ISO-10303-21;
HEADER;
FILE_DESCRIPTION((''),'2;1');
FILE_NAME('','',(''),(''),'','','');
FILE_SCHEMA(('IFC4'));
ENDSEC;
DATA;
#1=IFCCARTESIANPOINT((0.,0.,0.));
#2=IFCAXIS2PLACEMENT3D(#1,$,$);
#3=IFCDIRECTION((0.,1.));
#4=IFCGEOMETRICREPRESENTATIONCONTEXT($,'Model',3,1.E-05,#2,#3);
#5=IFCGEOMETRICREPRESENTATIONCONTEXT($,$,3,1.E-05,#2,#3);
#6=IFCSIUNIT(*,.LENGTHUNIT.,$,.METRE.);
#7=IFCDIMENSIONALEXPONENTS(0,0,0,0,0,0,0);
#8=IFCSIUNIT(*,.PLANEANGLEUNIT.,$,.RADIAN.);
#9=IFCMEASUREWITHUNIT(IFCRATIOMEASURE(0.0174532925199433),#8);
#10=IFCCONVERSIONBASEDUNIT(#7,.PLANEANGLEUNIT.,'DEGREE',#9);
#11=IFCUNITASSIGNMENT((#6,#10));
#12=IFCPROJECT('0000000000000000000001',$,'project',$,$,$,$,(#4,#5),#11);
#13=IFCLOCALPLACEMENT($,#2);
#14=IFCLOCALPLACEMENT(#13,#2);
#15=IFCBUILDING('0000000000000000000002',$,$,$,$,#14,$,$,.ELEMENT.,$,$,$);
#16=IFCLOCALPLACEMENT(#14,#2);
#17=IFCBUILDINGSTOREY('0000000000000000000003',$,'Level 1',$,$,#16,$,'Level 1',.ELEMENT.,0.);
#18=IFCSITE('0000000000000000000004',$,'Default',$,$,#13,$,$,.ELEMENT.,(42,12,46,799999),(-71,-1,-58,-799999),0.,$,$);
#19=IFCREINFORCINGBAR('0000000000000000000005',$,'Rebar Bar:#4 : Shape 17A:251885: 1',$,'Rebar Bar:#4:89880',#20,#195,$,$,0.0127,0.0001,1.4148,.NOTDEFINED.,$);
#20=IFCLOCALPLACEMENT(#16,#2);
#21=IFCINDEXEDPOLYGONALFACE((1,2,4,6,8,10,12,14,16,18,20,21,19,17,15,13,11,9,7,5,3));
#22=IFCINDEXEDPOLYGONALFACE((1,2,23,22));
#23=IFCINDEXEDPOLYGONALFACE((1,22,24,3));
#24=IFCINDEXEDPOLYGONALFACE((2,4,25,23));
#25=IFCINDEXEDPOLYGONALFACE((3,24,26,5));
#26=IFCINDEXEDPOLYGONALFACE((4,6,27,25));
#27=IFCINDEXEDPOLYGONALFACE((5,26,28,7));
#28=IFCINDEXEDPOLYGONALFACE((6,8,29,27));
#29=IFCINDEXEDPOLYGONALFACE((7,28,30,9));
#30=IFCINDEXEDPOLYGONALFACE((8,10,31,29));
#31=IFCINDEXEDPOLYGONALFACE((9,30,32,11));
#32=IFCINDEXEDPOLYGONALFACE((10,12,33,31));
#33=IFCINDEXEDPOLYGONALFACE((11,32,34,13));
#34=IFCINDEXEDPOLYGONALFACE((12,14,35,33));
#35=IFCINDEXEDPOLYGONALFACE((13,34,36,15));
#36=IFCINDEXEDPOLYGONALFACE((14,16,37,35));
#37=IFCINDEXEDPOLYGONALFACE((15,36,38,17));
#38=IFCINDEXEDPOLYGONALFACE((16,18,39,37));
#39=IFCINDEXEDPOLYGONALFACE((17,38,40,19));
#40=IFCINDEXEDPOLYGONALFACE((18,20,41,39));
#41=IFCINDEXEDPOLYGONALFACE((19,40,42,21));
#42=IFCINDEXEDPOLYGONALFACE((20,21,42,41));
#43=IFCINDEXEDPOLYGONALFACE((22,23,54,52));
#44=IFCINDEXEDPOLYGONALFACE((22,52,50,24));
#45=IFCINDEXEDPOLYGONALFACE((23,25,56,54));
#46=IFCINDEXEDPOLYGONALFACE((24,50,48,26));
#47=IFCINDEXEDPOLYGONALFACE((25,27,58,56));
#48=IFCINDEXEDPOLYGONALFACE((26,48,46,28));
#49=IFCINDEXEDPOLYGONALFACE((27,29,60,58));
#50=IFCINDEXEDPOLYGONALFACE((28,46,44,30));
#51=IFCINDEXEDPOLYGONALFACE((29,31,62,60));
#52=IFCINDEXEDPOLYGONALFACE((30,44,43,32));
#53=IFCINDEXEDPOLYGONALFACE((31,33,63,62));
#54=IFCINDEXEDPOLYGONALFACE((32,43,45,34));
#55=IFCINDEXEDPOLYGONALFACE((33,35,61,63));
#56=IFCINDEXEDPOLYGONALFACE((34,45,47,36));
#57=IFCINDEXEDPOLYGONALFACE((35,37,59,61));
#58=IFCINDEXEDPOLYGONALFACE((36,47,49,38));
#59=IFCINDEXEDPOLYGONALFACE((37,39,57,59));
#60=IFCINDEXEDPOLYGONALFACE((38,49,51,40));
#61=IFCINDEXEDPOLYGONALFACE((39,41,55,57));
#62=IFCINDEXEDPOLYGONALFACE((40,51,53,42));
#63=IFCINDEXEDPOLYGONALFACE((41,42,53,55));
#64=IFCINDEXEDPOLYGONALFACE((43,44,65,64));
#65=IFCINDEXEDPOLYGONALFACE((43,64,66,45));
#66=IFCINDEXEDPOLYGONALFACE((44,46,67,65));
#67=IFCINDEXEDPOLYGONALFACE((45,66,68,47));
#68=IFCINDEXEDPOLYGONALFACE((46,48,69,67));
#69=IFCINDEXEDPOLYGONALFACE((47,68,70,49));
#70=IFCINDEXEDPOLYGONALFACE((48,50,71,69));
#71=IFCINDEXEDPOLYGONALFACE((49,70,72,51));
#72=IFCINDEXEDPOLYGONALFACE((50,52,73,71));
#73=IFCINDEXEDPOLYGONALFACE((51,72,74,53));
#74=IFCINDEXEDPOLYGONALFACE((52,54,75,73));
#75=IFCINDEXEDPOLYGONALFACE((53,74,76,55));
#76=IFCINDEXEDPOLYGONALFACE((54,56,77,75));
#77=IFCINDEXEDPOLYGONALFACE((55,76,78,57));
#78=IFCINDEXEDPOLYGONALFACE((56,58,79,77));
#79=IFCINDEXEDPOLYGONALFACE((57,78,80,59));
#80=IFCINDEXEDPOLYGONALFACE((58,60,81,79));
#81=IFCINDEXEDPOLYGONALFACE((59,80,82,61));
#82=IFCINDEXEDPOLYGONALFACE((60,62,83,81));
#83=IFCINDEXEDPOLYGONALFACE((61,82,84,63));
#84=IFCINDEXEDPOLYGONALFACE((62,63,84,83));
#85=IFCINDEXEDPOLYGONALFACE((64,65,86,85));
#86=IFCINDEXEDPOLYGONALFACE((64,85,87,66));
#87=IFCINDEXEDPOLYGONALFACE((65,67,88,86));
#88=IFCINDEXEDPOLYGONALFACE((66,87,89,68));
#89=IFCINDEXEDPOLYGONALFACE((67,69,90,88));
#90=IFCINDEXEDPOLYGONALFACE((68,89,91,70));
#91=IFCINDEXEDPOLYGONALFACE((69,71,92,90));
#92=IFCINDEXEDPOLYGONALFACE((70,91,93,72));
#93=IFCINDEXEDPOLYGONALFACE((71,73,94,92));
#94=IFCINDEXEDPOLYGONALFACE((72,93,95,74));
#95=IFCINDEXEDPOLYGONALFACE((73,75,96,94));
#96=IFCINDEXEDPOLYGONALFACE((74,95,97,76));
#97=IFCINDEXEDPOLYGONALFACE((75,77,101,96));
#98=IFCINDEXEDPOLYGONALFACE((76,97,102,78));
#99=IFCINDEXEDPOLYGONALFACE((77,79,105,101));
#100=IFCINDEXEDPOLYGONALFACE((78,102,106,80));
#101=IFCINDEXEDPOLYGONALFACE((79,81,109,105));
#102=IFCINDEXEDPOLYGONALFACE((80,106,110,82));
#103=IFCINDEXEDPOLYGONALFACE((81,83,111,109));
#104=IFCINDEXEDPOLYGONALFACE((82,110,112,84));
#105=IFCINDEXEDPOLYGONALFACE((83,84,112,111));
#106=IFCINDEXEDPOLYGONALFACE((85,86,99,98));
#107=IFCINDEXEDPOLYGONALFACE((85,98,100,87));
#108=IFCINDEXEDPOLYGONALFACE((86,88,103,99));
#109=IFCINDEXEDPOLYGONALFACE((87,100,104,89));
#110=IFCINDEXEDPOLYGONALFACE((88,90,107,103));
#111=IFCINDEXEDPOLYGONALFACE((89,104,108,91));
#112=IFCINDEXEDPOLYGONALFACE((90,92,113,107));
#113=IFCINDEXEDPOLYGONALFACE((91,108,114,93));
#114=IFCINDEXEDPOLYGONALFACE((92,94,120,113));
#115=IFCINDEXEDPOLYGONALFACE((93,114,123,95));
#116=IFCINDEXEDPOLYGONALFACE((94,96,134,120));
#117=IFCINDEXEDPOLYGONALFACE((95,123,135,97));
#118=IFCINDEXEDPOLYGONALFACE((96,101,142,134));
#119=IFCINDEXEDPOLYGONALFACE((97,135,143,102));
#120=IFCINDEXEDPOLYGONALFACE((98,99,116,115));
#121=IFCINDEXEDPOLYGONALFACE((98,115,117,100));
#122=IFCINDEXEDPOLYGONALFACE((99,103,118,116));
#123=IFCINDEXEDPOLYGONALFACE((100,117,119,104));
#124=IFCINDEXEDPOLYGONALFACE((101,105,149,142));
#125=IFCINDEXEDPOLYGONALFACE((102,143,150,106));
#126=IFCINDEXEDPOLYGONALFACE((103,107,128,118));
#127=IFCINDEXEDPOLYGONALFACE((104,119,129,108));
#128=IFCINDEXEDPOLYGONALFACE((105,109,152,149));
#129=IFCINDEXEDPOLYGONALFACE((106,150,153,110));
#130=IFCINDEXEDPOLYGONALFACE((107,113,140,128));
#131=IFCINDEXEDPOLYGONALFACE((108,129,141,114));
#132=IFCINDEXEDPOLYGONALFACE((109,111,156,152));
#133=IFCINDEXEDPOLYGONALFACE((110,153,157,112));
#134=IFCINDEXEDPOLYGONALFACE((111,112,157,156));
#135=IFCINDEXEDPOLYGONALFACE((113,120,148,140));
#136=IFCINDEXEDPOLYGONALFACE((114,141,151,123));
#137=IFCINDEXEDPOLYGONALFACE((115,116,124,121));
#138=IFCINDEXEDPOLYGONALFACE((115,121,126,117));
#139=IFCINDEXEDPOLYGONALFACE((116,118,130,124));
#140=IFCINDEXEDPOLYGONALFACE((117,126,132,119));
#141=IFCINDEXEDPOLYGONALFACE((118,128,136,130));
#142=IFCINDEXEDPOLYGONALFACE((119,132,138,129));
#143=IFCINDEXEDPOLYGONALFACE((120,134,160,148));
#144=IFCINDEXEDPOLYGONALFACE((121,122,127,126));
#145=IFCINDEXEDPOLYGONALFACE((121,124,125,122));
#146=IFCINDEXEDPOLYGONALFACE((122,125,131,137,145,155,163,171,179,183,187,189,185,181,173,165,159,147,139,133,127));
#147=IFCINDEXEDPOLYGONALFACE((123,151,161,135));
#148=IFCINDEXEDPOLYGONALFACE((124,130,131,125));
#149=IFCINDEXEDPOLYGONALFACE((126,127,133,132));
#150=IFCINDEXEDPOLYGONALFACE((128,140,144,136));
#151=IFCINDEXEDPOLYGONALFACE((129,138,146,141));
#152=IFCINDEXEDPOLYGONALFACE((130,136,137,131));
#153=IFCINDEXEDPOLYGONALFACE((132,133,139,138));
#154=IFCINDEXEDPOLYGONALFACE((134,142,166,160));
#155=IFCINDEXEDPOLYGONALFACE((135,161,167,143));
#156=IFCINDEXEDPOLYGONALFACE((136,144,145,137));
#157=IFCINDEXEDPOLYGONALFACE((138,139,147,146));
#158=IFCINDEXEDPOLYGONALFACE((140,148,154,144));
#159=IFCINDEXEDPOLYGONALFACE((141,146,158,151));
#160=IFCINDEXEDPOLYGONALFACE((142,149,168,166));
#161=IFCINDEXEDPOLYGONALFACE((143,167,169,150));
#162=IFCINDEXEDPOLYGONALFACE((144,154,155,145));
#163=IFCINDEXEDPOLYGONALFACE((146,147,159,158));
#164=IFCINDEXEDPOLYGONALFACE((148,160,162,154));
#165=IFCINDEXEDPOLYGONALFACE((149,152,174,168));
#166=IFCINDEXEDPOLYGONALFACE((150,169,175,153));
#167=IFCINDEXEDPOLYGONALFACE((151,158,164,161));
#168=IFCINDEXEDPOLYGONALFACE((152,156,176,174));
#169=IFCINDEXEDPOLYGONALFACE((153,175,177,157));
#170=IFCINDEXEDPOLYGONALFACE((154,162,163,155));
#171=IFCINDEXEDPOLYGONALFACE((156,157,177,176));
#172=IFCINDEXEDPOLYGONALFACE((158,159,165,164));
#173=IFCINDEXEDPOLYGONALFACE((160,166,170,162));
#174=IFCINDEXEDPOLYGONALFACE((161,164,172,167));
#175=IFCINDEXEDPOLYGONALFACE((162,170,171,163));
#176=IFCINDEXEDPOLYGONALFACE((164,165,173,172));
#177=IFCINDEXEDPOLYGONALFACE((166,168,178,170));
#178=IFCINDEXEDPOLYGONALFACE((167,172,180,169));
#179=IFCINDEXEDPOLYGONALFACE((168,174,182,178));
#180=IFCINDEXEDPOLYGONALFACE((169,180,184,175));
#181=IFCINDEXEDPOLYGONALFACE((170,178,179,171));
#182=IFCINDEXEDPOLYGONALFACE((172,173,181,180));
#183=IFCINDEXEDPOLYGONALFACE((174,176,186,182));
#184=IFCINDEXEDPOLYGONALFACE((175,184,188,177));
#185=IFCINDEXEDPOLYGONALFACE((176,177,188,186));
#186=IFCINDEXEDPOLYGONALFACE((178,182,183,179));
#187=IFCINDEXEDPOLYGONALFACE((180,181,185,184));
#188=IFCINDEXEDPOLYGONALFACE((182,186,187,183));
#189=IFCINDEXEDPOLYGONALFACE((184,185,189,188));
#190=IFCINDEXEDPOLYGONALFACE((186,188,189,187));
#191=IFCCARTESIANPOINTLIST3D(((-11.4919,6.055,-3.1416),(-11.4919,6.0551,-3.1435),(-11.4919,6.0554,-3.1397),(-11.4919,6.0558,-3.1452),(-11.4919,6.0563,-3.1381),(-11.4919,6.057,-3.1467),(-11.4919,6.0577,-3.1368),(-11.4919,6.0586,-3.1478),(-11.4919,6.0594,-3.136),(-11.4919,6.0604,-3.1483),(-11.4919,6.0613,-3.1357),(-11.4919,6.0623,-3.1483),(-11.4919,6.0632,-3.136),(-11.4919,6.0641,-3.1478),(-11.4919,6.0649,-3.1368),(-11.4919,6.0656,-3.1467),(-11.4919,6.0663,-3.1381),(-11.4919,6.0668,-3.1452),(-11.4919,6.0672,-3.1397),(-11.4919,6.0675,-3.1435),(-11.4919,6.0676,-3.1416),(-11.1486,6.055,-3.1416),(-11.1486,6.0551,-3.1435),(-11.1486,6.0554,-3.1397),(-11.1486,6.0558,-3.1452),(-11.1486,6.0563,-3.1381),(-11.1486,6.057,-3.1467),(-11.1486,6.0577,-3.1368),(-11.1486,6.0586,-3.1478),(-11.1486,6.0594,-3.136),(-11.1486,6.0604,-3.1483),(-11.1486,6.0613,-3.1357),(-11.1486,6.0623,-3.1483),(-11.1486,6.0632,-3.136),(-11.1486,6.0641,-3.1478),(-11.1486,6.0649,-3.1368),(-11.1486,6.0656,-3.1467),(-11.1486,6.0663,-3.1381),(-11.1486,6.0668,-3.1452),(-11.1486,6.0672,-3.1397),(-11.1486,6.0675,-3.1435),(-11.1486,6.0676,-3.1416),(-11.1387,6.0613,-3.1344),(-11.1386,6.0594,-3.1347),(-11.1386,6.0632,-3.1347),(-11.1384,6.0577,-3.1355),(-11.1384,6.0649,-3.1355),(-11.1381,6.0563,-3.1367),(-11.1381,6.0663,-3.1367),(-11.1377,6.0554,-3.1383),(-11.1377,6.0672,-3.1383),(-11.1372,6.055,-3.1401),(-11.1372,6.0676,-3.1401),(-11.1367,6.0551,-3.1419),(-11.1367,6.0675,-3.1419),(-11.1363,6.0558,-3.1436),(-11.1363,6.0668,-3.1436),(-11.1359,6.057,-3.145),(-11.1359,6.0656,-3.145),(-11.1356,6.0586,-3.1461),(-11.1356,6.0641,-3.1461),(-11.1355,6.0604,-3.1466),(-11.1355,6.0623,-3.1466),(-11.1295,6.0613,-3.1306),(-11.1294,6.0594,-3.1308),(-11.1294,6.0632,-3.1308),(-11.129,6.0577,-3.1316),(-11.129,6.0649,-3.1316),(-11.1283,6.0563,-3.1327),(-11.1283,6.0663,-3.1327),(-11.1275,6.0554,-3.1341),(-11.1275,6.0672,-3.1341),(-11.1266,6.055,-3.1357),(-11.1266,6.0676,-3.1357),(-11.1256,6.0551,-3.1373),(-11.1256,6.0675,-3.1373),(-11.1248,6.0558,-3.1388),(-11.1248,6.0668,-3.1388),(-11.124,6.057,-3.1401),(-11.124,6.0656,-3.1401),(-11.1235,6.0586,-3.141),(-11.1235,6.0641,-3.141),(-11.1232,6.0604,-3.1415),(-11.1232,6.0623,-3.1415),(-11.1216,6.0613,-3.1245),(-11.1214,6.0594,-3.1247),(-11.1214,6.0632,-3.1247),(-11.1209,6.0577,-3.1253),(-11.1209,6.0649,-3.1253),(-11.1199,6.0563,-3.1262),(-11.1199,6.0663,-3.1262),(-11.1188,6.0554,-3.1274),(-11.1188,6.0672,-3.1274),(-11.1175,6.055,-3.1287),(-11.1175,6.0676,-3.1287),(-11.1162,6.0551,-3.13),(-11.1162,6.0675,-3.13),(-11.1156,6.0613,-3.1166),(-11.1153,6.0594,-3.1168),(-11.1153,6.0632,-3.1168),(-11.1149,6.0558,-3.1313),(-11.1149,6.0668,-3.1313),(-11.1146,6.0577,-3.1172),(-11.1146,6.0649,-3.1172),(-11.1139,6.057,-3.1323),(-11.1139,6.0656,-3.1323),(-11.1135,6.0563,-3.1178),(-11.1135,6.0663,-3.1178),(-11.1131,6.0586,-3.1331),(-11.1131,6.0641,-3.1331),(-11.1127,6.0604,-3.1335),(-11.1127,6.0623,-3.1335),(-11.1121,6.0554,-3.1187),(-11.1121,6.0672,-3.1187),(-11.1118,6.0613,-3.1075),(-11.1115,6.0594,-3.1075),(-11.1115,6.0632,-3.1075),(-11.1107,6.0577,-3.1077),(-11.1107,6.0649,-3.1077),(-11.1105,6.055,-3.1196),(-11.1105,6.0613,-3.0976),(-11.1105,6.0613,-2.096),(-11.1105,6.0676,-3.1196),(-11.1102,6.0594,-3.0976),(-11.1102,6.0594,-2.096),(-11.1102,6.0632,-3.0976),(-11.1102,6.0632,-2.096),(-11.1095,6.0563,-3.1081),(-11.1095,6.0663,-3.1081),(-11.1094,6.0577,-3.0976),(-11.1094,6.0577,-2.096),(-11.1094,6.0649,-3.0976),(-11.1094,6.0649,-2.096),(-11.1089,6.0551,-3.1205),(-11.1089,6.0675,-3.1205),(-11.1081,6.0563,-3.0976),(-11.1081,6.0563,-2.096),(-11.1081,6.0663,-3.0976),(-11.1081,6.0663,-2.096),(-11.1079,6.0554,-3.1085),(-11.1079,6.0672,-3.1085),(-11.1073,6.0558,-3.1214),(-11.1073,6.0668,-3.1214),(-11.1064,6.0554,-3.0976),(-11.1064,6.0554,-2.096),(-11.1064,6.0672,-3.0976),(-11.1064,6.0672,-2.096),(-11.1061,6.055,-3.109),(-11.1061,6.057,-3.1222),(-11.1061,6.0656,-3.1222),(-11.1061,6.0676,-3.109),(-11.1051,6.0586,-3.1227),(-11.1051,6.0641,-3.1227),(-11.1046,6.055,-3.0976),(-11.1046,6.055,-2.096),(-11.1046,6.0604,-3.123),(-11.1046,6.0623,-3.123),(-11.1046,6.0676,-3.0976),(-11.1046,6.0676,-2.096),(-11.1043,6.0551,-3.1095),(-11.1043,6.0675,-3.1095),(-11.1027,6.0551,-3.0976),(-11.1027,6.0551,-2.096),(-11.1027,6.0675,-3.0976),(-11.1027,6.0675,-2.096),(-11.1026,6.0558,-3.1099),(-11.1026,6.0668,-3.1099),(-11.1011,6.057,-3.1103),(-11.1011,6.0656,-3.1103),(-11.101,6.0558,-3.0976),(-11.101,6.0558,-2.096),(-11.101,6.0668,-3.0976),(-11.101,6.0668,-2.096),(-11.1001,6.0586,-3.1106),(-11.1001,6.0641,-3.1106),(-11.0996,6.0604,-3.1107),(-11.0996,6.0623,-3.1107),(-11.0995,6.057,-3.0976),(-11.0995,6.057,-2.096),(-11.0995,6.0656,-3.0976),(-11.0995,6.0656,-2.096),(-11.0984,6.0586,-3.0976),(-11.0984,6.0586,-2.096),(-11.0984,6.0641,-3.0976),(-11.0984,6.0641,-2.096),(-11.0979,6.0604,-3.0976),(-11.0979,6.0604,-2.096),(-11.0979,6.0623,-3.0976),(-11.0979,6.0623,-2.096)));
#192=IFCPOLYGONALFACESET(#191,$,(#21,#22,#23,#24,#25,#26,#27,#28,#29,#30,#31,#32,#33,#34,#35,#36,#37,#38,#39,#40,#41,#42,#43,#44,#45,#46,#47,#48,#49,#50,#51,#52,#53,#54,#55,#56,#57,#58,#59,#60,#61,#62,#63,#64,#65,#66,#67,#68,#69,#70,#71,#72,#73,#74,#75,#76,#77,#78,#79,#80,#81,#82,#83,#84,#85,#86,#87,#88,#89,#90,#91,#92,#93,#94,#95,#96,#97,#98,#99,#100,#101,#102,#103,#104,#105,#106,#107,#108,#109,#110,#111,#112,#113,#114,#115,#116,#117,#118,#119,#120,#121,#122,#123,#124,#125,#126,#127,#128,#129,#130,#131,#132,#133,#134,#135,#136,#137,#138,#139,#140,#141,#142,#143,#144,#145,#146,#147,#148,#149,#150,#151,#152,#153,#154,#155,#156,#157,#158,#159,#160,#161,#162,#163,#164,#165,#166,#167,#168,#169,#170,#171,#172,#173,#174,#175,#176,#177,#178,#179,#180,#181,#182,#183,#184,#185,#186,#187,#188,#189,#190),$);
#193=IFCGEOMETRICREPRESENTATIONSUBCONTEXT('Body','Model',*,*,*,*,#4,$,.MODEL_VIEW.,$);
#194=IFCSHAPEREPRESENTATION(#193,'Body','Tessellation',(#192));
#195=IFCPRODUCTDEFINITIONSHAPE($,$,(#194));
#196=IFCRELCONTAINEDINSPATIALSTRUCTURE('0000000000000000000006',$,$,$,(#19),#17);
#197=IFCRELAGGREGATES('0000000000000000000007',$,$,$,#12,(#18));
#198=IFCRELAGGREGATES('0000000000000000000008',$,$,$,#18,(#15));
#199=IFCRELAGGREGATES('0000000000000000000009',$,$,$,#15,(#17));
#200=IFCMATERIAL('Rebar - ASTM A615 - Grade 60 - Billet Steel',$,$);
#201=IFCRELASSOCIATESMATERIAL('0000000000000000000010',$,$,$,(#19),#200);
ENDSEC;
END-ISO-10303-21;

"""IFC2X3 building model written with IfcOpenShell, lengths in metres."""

from ifc_helpers import new_model, entity, si_unit, converted_unit, direction, origin, place, context, subcontext, project, spatial, material, element, save


model = new_model("IFC2X3")

# Units and contexts
model_context = context("Model", 3, precision=1e-05, world=origin(), true_north=direction((0.0, 1.0)))
context_of_model = context(None, 3, precision=1e-05, world=origin(), true_north=direction((0.0, 1.0)))
body_context = subcontext(model_context, "Body", "Model", "MODEL_VIEW")
ifc_project = project(units=[si_unit("LENGTHUNIT", "METRE"), converted_unit("PLANEANGLEUNIT", "DEGREE", entity("IfcRatioMeasure", 0.0174532925199433), si_unit("PLANEANGLEUNIT", "RADIAN"), dimensions=[0, 0, 0, 0, 0, 0, 0])], contexts=[model_context, context_of_model])

# Site, building, storey
site_placement = place(None, origin())
site = spatial("IfcSite", under=ifc_project, at=site_placement, Name="Default", CompositionType="ELEMENT", RefLatitude=(42, 12, 46, 799999), RefLongitude=(-71, -1, -58, -799999), RefElevation=0.0)
building_placement = place(site_placement, origin())
building = spatial("IfcBuilding", under=site, at=building_placement, CompositionType="ELEMENT")
storey_placement = place(building_placement, origin())
storey = spatial("IfcBuildingStorey", under=building, at=storey_placement, Name="Level 1", LongName="Level 1", CompositionType="ELEMENT", Elevation=0.0)

# Reinforcing bar
ifc_material_1 = material(Name="Rebar - ASTM A615 - Grade 60 - Billet Steel")
reinforcing_bar_1_placement = place(storey_placement, origin())
element("IfcReinforcingBar", 1, at=reinforcing_bar_1_placement, inside=storey, material=ifc_material_1, Name="Rebar Bar:#4 : Shape 17A:251885: 1", ObjectType="Rebar Bar:#4:89880", BarLength=1.4148, BarRole="NOTDEFINED", CrossSectionArea=0.0001, NominalDiameter=0.0127, context=body_context, shape_type="AdvancedSweptSolid", body=[
    entity("IfcSweptDiskSolid", entity("IfcCompositeCurve", [entity("IfcCompositeCurveSegment", "CONTINUOUS", True, entity("IfcPolyline", [entity("IfcCartesianPoint", [-11.4919, 6.0613, -3.142]), entity("IfcCartesianPoint", [-11.1486, 6.0613, -3.142])])), entity("IfcCompositeCurveSegment", "CONTINUOUS", True, entity("IfcTrimmedCurve", entity("IfcCircle", entity("IfcAxis2Placement3D", entity("IfcCartesianPoint", [-11.1486, 6.0613, -3.0976]), entity("IfcDirection", [0.0, -1.0, 0.0]), entity("IfcDirection", [1.0, 0.0, 0.0])), 0.0445), [entity("IfcParameterValue", 270.0)], [entity("IfcParameterValue", 360.0)], True, "PARAMETER")), entity("IfcCompositeCurveSegment", "CONTINUOUS", True, entity("IfcPolyline", [entity("IfcCartesianPoint", [-11.1041, 6.0613, -3.0976]), entity("IfcCartesianPoint", [-11.1041, 6.0613, -2.096])]))], False), 0.0063, None, 0.0, 92.0),
])

save(model, "model.ifc")
